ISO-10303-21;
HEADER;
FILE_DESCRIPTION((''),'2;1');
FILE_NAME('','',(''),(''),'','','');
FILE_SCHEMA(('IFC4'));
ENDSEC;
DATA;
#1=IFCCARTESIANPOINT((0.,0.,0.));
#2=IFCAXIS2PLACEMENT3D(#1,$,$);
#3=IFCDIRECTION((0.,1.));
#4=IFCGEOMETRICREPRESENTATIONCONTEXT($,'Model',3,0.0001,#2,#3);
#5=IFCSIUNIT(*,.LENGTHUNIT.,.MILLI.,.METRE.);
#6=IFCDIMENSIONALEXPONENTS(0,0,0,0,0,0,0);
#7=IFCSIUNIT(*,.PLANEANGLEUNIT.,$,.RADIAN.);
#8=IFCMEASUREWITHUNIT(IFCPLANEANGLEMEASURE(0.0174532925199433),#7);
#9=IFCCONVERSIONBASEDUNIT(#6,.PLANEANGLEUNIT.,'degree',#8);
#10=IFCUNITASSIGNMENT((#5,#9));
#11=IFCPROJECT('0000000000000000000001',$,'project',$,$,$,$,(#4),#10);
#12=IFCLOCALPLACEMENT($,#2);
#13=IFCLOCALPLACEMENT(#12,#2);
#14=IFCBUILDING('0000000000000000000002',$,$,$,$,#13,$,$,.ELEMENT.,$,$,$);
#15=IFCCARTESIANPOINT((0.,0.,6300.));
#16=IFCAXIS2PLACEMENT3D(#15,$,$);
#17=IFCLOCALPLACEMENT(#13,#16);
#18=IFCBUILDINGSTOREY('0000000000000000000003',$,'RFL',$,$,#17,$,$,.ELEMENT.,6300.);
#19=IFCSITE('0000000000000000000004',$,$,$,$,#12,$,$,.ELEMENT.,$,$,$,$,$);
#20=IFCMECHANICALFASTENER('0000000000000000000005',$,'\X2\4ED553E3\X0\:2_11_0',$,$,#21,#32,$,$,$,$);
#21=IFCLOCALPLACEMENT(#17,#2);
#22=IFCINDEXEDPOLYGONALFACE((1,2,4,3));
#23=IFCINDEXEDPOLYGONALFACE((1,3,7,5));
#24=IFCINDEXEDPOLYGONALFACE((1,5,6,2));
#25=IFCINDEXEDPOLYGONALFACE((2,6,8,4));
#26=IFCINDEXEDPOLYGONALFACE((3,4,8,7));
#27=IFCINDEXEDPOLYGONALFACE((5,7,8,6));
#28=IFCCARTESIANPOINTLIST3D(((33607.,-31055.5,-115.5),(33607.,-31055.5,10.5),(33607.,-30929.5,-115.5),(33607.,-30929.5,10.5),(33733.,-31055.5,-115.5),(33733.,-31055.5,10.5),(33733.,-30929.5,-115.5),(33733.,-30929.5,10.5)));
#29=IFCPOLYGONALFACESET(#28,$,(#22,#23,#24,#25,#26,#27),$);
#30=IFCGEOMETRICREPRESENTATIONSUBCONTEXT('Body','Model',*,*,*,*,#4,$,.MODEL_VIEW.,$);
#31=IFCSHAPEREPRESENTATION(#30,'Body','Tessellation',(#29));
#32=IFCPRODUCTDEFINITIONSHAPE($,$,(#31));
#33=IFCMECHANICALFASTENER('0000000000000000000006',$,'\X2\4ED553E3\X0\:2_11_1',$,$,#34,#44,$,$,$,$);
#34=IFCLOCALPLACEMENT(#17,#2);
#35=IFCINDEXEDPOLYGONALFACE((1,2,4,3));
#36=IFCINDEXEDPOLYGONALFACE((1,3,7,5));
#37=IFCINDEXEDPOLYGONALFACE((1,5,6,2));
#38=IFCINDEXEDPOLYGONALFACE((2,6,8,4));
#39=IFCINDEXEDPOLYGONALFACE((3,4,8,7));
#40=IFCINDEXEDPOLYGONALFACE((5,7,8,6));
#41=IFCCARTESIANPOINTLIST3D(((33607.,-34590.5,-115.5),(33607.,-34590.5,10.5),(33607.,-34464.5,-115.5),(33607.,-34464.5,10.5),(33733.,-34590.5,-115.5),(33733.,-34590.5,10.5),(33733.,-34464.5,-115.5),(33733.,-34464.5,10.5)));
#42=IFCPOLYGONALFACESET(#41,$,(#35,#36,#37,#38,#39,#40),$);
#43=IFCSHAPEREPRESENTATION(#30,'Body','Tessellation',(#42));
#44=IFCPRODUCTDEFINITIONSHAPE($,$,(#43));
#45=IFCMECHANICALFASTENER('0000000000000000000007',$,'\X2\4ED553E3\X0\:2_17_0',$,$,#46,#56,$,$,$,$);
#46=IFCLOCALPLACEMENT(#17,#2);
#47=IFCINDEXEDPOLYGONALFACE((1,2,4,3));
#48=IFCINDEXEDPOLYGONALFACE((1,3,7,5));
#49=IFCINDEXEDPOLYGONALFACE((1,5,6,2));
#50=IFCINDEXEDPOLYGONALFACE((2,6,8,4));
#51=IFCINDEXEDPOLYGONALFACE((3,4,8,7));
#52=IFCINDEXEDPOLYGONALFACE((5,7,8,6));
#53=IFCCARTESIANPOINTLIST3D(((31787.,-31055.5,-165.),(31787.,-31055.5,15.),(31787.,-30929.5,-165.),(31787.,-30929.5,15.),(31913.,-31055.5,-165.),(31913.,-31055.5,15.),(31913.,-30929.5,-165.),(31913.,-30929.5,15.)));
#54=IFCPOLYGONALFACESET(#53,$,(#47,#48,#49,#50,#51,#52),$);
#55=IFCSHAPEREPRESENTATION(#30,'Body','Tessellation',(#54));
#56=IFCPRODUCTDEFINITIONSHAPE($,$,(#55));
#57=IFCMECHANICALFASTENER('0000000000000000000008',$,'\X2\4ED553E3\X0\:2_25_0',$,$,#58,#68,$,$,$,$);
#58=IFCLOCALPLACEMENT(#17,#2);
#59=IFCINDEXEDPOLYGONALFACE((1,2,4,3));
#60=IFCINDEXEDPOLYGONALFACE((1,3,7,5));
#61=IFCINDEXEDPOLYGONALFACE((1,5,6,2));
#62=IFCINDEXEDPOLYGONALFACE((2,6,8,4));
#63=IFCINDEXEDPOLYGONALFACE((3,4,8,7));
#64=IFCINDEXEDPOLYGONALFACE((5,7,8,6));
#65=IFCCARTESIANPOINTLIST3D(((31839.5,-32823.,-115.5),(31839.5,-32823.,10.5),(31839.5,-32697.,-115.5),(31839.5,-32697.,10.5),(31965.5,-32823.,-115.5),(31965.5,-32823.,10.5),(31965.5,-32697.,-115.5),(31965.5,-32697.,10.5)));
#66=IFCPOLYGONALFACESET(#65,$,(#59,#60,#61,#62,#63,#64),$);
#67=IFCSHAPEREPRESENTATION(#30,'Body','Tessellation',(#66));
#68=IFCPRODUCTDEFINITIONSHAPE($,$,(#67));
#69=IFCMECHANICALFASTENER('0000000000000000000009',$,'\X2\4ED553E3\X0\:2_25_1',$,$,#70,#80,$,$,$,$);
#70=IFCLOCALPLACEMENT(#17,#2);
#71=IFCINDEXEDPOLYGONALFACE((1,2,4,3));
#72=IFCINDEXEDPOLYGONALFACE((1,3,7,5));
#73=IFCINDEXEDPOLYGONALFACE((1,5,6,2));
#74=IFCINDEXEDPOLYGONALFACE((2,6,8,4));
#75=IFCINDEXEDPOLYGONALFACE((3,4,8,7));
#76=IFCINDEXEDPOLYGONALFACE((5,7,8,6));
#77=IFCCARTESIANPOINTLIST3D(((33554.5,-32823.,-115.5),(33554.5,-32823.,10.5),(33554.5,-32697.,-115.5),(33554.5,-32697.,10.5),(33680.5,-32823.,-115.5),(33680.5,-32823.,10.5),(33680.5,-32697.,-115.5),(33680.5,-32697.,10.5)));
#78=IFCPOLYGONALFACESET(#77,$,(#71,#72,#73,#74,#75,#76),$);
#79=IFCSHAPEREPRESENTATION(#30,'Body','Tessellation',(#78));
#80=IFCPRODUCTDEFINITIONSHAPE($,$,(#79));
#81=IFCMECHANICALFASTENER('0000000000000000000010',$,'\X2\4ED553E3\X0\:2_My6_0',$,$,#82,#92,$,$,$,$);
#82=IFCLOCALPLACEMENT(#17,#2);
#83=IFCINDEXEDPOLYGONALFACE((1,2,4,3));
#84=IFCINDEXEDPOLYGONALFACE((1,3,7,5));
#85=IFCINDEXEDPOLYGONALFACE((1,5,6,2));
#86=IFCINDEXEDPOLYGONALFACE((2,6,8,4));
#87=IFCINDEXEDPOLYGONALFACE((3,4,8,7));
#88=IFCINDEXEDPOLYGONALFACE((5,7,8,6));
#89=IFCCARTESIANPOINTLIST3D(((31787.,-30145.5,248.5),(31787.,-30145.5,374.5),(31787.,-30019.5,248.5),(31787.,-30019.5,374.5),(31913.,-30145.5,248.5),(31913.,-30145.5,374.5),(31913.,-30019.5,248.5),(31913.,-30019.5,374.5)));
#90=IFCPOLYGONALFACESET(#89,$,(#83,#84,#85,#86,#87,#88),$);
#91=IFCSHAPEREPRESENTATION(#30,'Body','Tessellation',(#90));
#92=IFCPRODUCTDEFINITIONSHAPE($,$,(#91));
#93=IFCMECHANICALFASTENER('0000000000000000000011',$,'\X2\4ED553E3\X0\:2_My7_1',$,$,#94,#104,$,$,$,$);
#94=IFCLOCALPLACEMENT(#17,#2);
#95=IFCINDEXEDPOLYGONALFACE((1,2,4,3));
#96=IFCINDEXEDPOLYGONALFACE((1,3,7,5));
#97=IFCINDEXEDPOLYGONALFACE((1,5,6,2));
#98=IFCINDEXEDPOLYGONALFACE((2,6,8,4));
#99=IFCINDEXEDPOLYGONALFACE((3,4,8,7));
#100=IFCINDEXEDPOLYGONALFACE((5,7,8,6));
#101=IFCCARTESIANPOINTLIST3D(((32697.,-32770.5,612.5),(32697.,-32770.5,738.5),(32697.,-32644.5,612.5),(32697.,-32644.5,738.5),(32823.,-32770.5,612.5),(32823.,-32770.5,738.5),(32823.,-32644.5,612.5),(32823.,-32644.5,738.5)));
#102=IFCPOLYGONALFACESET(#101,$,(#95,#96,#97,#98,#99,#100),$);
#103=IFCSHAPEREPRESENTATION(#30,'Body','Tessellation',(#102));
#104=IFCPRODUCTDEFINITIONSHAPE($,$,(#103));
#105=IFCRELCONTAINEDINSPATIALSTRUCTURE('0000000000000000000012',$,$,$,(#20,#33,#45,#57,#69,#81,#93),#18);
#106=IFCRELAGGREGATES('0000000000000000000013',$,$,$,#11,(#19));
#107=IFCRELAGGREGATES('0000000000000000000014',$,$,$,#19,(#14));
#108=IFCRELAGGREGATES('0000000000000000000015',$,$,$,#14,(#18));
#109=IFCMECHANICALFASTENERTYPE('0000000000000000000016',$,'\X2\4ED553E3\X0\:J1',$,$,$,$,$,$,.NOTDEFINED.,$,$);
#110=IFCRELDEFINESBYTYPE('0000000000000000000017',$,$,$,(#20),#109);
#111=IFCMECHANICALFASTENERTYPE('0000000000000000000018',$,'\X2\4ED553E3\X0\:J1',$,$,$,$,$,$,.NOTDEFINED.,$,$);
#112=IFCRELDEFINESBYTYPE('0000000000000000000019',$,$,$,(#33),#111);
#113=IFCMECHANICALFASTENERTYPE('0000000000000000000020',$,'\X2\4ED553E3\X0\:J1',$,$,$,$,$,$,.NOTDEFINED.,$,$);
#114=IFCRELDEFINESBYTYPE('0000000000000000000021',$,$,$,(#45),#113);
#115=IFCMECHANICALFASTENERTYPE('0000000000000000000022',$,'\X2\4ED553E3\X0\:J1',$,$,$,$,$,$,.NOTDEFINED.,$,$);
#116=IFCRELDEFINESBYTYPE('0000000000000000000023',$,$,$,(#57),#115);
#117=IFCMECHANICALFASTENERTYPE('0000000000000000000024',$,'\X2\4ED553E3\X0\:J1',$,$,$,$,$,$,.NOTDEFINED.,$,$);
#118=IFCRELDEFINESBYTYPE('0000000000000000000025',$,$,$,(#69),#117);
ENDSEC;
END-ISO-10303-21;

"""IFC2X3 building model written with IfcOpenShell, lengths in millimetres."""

from ifc_helpers import new_model, entity, si_unit, converted_unit, direction, frame, origin, origin_with_axes, origin_2d, place, context, subcontext, project, spatial, rectangle, extrude, type_object, element, save


model = new_model("IFC2X3")

# Units and contexts
model_context = context("Model", 3, precision=0.0001, world=origin(), true_north=direction((0.0, 1.0)))
body_context = subcontext(model_context, "Body", "Model", "MODEL_VIEW")
ifc_project = project(units=[si_unit("LENGTHUNIT", "METRE", prefix="MILLI"), converted_unit("PLANEANGLEUNIT", "degree", entity("IfcPlaneAngleMeasure", 0.0174532925199433), si_unit("PLANEANGLEUNIT", "RADIAN"), dimensions=[0, 0, 0, 0, 0, 0, 0])], contexts=[model_context])

# Site, building, storey
site_placement = place(None, origin())
site = spatial("IfcSite", under=ifc_project, at=site_placement, CompositionType="ELEMENT")
building_placement = place(site_placement, origin())
building = spatial("IfcBuilding", under=site, at=building_placement, CompositionType="ELEMENT")
storey_placement = place(building_placement, frame((0.0, 0.0, 6300.0)))
storey = spatial("IfcBuildingStorey", under=building, at=storey_placement, Name="RFL", CompositionType="ELEMENT", Elevation=6300.0)

# Mechanical fasteners
mechanical_fastener_type_1 = type_object("IfcMechanicalFastenerType", Name="仕口:J1")
mechanical_fastener_1_placement = place(storey_placement, frame((33670.0, -30992.5, -115.5)))
element("IfcMechanicalFastener", 1, at=mechanical_fastener_1_placement, inside=storey, type_object=mechanical_fastener_type_1, Name="仕口:2_11_0", context=body_context, shape_type="SweptSolid", body=[
    extrude(rectangle(XDim=126.0, YDim=126.0, at=origin_2d()), origin_with_axes(), (0.0, 0.0, 1.0), 126.0),
])
mechanical_fastener_type_2 = type_object("IfcMechanicalFastenerType", Name="仕口:J1")
mechanical_fastener_2_placement = place(storey_placement, frame((33670.0, -34527.5, -115.5)))
element("IfcMechanicalFastener", 2, at=mechanical_fastener_2_placement, inside=storey, type_object=mechanical_fastener_type_2, Name="仕口:2_11_1", context=body_context, shape_type="SweptSolid", body=[
    extrude(rectangle(XDim=126.0, YDim=126.0, at=origin_2d()), origin_with_axes(), (0.0, 0.0, 1.0), 126.0),
])
mechanical_fastener_type_3 = type_object("IfcMechanicalFastenerType", Name="仕口:J1")
mechanical_fastener_3_placement = place(storey_placement, frame((31850.0, -30992.5, -165.0)))
element("IfcMechanicalFastener", 3, at=mechanical_fastener_3_placement, inside=storey, type_object=mechanical_fastener_type_3, Name="仕口:2_17_0", context=body_context, shape_type="SweptSolid", body=[
    extrude(rectangle(XDim=126.0, YDim=126.0, at=origin_2d()), origin_with_axes(), (0.0, 0.0, 1.0), 180.0),
])
mechanical_fastener_type_4 = type_object("IfcMechanicalFastenerType", Name="仕口:J1")
mechanical_fastener_4_placement = place(storey_placement, frame((31902.5, -32760.0, -115.5)))
element("IfcMechanicalFastener", 4, at=mechanical_fastener_4_placement, inside=storey, type_object=mechanical_fastener_type_4, Name="仕口:2_25_0", context=body_context, shape_type="SweptSolid", body=[
    extrude(rectangle(XDim=126.0, YDim=126.0, at=origin_2d()), origin_with_axes(), (0.0, 0.0, 1.0), 126.0),
])
mechanical_fastener_type_5 = type_object("IfcMechanicalFastenerType", Name="仕口:J1")
mechanical_fastener_5_placement = place(storey_placement, frame((33617.5, -32760.0, -115.5)))
element("IfcMechanicalFastener", 5, at=mechanical_fastener_5_placement, inside=storey, type_object=mechanical_fastener_type_5, Name="仕口:2_25_1", context=body_context, shape_type="SweptSolid", body=[
    extrude(rectangle(XDim=126.0, YDim=126.0, at=origin_2d()), origin_with_axes(), (0.0, 0.0, 1.0), 126.0),
])
for number, where, name in (
    (6, (31850.0, -30082.5, 248.5), "仕口:2_My6_0"),
    (7, (32760.0, -32707.5, 612.5), "仕口:2_My7_1"),
):
    element("IfcMechanicalFastener", number, at=place(storey_placement, frame(where)), inside=storey, Name=name, context=body_context, shape_type="SweptSolid", body=[
        extrude(rectangle(XDim=126.0, YDim=126.0, at=origin_2d()), origin_with_axes(), (0.0, 0.0, 1.0), 126.0),
    ])

save(model, "model.ifc")
